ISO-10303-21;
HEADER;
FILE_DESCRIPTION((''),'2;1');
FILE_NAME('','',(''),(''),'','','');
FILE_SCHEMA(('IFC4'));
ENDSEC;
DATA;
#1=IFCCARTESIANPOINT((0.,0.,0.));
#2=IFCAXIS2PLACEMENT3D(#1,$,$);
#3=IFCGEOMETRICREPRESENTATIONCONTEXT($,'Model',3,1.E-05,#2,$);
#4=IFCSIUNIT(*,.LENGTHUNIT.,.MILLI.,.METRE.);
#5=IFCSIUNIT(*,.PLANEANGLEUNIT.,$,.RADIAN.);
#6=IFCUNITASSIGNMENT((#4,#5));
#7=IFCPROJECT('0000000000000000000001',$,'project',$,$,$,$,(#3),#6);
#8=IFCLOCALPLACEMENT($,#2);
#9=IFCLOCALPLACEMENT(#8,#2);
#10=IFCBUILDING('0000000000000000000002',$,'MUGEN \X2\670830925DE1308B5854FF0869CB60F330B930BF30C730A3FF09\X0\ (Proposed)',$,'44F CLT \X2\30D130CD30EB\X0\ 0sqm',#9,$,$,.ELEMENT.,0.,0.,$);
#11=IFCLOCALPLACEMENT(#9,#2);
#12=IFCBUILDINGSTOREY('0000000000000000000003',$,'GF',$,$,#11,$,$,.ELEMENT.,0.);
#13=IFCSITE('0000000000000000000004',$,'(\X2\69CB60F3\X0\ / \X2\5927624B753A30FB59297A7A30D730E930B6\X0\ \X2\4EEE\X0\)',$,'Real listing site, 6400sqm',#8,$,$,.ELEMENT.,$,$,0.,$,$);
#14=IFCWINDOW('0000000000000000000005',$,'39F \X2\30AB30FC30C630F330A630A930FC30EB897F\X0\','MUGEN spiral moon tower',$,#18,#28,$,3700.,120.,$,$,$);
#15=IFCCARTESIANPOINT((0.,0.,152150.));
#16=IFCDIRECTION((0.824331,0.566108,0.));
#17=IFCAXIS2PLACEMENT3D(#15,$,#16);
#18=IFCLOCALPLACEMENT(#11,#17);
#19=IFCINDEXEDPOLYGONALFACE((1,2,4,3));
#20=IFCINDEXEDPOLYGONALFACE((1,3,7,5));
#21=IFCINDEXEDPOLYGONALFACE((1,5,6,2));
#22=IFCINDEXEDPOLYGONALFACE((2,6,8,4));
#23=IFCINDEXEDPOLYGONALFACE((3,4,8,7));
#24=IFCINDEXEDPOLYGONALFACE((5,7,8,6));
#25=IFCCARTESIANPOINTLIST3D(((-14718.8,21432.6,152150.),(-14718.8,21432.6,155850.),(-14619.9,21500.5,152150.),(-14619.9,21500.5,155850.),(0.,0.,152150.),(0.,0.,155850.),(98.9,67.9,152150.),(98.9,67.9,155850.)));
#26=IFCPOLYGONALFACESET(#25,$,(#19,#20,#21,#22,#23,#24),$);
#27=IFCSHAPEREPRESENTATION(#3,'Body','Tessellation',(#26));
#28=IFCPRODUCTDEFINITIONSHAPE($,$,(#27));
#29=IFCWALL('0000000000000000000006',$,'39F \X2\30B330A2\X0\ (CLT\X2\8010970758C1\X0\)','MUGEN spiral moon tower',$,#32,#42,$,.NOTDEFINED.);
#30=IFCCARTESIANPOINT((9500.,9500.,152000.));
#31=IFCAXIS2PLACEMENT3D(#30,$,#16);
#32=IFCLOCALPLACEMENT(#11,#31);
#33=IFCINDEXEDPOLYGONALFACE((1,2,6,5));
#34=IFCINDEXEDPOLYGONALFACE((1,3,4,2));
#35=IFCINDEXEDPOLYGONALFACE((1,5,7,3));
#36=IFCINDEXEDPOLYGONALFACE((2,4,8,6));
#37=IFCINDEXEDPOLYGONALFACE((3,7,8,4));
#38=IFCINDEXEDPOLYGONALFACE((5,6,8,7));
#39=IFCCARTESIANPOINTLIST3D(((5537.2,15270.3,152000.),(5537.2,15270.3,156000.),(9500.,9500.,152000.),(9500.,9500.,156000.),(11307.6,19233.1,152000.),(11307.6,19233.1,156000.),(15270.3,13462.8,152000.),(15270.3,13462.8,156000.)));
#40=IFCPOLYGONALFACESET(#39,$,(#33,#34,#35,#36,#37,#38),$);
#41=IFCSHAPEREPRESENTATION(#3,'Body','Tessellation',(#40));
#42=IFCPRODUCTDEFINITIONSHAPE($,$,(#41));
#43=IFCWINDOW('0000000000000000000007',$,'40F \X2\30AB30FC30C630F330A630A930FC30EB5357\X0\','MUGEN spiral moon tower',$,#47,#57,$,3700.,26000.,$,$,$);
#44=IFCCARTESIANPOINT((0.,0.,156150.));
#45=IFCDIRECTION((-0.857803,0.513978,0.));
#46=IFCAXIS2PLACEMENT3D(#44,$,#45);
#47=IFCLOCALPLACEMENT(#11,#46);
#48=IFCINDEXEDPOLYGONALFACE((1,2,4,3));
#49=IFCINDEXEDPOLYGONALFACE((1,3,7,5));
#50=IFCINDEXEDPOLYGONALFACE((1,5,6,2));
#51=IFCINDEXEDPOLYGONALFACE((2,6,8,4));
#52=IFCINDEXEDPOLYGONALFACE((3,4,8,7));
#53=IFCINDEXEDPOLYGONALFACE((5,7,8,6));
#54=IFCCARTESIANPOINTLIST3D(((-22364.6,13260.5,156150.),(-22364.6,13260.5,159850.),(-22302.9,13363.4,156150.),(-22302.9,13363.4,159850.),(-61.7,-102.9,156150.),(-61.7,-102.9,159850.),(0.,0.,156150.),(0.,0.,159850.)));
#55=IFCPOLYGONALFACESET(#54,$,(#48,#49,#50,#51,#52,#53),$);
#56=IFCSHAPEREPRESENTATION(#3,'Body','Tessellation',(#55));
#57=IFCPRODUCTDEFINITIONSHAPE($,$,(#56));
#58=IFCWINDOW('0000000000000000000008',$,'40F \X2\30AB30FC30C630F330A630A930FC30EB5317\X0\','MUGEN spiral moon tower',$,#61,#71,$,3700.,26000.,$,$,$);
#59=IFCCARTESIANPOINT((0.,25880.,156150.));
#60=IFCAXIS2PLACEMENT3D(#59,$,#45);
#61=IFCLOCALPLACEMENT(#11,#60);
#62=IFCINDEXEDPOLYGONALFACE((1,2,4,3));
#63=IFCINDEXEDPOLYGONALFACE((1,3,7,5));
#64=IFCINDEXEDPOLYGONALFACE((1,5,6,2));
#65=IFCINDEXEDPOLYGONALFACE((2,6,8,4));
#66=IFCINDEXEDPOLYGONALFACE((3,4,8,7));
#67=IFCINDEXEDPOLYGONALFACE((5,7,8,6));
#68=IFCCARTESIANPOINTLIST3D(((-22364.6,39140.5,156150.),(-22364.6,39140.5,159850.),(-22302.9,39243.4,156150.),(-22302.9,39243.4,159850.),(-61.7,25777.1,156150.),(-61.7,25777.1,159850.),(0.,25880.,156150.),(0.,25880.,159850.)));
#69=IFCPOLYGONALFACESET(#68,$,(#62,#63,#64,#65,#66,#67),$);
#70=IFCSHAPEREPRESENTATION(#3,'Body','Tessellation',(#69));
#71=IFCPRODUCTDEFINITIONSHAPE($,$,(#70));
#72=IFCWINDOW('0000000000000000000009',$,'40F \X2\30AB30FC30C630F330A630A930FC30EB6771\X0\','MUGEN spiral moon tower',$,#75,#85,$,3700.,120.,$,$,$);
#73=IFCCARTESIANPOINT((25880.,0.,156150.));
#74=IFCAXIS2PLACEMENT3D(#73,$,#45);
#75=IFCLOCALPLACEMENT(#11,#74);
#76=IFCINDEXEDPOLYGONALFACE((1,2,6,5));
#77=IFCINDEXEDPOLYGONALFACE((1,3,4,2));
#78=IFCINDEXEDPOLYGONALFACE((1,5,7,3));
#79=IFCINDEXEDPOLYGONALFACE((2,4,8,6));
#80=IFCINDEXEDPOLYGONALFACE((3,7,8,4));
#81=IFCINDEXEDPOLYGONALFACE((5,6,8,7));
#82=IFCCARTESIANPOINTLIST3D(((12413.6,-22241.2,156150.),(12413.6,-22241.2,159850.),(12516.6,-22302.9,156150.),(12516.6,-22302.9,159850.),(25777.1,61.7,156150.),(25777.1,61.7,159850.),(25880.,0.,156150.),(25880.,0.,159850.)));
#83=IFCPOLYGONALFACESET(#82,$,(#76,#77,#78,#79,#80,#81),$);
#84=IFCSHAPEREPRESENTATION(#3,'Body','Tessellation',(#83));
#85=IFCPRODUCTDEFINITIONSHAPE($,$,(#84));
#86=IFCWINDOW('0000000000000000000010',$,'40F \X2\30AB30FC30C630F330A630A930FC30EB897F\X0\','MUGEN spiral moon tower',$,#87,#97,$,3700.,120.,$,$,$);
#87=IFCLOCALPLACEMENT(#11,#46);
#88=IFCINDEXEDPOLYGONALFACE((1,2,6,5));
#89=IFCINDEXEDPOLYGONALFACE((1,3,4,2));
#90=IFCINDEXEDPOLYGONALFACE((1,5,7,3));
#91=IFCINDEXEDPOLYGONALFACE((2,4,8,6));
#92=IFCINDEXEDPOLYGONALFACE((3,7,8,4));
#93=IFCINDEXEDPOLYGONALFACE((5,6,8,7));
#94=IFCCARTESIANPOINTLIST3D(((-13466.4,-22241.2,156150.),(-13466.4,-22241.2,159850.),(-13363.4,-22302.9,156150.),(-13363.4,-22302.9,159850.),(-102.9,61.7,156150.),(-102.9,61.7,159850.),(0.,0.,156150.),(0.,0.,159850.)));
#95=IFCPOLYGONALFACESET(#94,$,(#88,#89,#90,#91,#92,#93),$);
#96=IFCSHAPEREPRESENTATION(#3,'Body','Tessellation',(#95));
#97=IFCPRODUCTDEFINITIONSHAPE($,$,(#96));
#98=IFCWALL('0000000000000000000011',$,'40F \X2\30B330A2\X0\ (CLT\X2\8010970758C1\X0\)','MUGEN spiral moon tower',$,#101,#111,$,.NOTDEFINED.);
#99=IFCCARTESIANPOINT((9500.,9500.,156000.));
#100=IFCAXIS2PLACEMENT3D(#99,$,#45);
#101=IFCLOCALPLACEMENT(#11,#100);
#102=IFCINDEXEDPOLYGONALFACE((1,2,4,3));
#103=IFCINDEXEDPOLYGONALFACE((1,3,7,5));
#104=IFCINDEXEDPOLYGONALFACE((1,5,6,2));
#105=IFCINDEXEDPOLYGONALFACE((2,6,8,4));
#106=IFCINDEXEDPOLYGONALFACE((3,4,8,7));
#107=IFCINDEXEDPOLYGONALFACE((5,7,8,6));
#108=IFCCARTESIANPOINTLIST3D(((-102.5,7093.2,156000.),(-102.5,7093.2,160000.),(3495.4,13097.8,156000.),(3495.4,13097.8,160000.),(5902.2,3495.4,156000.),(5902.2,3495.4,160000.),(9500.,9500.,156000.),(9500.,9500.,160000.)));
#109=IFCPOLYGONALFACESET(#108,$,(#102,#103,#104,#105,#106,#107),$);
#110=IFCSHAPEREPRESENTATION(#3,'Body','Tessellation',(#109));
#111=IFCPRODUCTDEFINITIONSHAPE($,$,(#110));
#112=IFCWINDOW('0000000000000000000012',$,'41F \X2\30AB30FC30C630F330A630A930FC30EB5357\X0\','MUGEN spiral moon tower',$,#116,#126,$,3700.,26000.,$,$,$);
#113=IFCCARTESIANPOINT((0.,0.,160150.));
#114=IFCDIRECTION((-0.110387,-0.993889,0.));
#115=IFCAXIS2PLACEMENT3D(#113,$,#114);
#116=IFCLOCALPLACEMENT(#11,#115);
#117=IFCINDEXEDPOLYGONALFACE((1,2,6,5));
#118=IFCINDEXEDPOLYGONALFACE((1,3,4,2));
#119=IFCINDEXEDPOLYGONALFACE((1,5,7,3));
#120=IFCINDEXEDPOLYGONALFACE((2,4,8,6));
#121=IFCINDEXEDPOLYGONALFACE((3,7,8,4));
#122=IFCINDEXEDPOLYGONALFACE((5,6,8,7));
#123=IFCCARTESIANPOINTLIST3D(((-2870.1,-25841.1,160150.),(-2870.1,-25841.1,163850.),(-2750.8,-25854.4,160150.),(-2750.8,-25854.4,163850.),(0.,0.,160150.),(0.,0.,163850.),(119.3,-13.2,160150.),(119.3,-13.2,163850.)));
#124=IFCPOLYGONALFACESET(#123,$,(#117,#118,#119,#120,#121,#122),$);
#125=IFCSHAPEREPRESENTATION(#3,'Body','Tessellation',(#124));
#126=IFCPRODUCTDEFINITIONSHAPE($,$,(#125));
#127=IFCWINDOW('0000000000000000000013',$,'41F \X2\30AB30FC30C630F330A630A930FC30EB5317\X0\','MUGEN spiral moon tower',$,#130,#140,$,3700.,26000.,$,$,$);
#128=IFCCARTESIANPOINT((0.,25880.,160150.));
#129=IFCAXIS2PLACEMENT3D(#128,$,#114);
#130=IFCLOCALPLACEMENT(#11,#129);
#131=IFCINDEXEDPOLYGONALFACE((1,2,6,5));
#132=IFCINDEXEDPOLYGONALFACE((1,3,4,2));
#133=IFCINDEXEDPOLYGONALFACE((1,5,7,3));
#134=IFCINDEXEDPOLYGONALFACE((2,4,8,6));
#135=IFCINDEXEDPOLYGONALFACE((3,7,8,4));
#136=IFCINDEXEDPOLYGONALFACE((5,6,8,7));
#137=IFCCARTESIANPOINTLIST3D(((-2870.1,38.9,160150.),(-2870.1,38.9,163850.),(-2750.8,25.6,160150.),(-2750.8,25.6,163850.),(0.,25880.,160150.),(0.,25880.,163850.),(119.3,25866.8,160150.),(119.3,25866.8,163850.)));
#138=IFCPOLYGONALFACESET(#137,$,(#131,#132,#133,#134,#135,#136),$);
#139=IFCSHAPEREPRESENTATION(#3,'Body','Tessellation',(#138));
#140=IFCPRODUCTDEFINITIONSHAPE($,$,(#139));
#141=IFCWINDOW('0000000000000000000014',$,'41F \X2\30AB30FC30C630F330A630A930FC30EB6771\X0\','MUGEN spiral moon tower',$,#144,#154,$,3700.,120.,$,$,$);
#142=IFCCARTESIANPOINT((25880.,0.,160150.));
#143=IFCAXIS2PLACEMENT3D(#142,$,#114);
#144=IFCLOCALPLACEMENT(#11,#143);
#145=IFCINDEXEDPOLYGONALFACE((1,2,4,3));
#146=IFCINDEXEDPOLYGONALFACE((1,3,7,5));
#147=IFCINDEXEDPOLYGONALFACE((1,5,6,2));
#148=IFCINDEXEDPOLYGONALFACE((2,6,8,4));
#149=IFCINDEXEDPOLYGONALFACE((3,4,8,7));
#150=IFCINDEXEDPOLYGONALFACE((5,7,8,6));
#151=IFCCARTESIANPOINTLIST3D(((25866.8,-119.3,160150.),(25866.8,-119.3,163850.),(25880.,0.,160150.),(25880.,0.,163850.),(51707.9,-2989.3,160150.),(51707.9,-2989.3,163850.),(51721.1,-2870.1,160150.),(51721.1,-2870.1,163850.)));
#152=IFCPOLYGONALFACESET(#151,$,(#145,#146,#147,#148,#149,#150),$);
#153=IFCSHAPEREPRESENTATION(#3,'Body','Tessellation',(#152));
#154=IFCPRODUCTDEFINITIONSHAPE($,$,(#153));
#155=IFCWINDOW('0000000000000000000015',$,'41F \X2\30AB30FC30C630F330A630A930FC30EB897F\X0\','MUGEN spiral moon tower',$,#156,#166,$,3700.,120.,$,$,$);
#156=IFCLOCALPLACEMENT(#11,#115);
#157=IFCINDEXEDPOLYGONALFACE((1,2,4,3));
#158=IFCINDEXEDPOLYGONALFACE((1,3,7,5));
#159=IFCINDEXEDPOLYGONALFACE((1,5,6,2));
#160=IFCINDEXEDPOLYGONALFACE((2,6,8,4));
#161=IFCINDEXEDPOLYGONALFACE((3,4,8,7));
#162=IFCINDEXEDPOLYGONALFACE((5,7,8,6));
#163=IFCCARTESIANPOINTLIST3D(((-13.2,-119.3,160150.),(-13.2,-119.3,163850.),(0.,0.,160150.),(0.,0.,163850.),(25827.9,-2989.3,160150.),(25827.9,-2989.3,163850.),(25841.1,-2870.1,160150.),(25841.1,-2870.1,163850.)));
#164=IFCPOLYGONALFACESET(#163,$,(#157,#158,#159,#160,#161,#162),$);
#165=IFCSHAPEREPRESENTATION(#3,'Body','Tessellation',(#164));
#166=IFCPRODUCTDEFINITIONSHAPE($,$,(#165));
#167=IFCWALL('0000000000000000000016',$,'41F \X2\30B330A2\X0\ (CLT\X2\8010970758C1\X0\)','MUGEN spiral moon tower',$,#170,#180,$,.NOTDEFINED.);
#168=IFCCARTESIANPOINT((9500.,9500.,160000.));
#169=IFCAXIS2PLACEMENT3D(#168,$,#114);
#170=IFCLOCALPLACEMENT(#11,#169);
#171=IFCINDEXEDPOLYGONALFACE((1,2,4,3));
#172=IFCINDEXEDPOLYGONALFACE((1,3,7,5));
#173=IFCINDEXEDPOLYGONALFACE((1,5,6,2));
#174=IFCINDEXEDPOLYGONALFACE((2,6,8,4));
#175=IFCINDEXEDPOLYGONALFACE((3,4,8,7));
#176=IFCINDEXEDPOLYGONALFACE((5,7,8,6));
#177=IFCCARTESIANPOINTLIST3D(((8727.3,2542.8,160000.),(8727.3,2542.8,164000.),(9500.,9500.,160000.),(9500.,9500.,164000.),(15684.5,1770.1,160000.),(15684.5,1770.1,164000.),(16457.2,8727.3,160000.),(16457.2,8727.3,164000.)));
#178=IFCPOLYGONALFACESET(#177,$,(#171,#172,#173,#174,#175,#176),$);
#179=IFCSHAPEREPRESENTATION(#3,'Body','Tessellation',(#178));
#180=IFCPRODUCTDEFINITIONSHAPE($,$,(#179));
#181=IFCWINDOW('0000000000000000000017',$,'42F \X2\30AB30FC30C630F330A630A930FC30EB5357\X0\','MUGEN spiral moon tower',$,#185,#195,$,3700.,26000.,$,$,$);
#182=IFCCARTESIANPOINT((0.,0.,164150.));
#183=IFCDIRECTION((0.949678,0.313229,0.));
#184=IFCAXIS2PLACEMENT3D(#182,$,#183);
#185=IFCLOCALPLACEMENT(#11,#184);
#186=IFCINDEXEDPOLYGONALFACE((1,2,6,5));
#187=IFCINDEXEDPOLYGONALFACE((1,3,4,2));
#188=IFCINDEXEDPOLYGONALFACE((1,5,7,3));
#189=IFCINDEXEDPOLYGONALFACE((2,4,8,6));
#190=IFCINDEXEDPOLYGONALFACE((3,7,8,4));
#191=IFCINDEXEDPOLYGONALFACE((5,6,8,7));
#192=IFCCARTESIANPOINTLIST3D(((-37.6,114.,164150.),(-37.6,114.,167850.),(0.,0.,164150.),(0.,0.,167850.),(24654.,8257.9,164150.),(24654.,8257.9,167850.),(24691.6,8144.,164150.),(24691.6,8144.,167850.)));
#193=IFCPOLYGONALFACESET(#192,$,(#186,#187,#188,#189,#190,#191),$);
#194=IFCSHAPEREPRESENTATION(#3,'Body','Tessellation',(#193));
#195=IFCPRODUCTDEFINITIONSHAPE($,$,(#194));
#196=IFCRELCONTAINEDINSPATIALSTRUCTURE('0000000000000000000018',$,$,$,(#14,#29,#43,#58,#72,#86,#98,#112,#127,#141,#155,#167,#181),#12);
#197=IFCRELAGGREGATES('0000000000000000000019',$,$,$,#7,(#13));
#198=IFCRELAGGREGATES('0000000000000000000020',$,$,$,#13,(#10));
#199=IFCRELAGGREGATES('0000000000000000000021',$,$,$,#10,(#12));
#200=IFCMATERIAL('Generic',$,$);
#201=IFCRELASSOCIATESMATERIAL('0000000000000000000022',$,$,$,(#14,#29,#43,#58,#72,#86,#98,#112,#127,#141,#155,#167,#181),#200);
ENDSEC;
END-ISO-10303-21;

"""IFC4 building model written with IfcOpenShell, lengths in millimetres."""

from ifc_helpers import new_model, si_unit, frame, frame_2d, origin, place, context, project, spatial, rectangle, extrude, material, element, save


model = new_model("IFC4")

# Units and contexts
model_context = context("Model", 3, precision=1e-05, world=origin())
ifc_project = project(units=[si_unit("LENGTHUNIT", "METRE", prefix="MILLI"), si_unit("PLANEANGLEUNIT", "RADIAN")], contexts=[model_context])

# Site, building, storey
site_placement = place(None, origin())
site = spatial("IfcSite", under=ifc_project, at=site_placement, Name="(構想 / 大手町・天空プラザ 仮)", ObjectType="Real listing site, 6400sqm", CompositionType="ELEMENT", RefElevation=0.0)
building_placement = place(site_placement, origin())
building = spatial("IfcBuilding", under=site, at=building_placement, Name="MUGEN 月を巡る塔（構想スタディ） (Proposed)", ObjectType="44F CLT パネル 0sqm", CompositionType="ELEMENT", ElevationOfRefHeight=0.0, ElevationOfTerrain=0.0)
storey_placement = place(building_placement, origin())
storey = spatial("IfcBuildingStorey", under=building, at=storey_placement, Name="GF", CompositionType="ELEMENT", Elevation=0.0)

# Shared definitions
ifc_material = material(Name="Generic")

# Window
window_1_placement = place(storey_placement, frame((0.0, 0.0, 152150.0), x_axis=(0.824331, 0.566108, 0.0)))
element("IfcWindow", 1, at=window_1_placement, inside=storey, material=ifc_material, Name="39F カーテンウォール西", Description="MUGEN spiral moon tower", OverallHeight=3700.0, OverallWidth=120.0, context=model_context, shape_type="SweptSolid", body=[
    extrude(rectangle(XDim=120.0, YDim=26000.0, at=frame_2d((60.0, 13000.0))), frame((0.0, 0.0, 152150.0), x_axis=(0.824331, 0.566108, 0.0)), (0.0, 0.0, 1.0), 3700.0),
])

# Wall
wall_1_placement = place(storey_placement, frame((9500.0, 9500.0, 152000.0), x_axis=(0.824331, 0.566108, 0.0)))
element("IfcWall", 2, at=wall_1_placement, inside=storey, material=ifc_material, Name="39F コア (CLT耐震壁)", Description="MUGEN spiral moon tower", PredefinedType="NOTDEFINED", context=model_context, shape_type="SweptSolid", body=[
    extrude(rectangle(XDim=7000.0, YDim=7000.0, at=frame_2d((3500.0, 3500.0))), frame((9500.0, 9500.0, 152000.0), x_axis=(0.824331, 0.566108, 0.0)), (0.0, 0.0, 1.0), 4000.0),
])

# Windows
window_2_placement = place(storey_placement, frame((0.0, 0.0, 156150.0), x_axis=(-0.857803, 0.513978, 0.0)))
element("IfcWindow", 3, at=window_2_placement, inside=storey, material=ifc_material, Name="40F カーテンウォール南", Description="MUGEN spiral moon tower", OverallHeight=3700.0, OverallWidth=26000.0, context=model_context, shape_type="SweptSolid", body=[
    extrude(rectangle(XDim=26000.0, YDim=120.0, at=frame_2d((13000.0, 60.0))), frame((0.0, 0.0, 156150.0), x_axis=(-0.857803, 0.513978, 0.0)), (0.0, 0.0, 1.0), 3700.0),
])
window_3_placement = place(storey_placement, frame((0.0, 25880.0, 156150.0), x_axis=(-0.857803, 0.513978, 0.0)))
element("IfcWindow", 4, at=window_3_placement, inside=storey, material=ifc_material, Name="40F カーテンウォール北", Description="MUGEN spiral moon tower", OverallHeight=3700.0, OverallWidth=26000.0, context=model_context, shape_type="SweptSolid", body=[
    extrude(rectangle(XDim=26000.0, YDim=120.0, at=frame_2d((13000.0, 60.0))), frame((0.0, 25880.0, 156150.0), x_axis=(-0.857803, 0.513978, 0.0)), (0.0, 0.0, 1.0), 3700.0),
])
window_4_placement = place(storey_placement, frame((25880.0, 0.0, 156150.0), x_axis=(-0.857803, 0.513978, 0.0)))
element("IfcWindow", 5, at=window_4_placement, inside=storey, material=ifc_material, Name="40F カーテンウォール東", Description="MUGEN spiral moon tower", OverallHeight=3700.0, OverallWidth=120.0, context=model_context, shape_type="SweptSolid", body=[
    extrude(rectangle(XDim=120.0, YDim=26000.0, at=frame_2d((60.0, 13000.0))), frame((25880.0, 0.0, 156150.0), x_axis=(-0.857803, 0.513978, 0.0)), (0.0, 0.0, 1.0), 3700.0),
])
window_5_placement = place(storey_placement, frame((0.0, 0.0, 156150.0), x_axis=(-0.857803, 0.513978, 0.0)))
element("IfcWindow", 6, at=window_5_placement, inside=storey, material=ifc_material, Name="40F カーテンウォール西", Description="MUGEN spiral moon tower", OverallHeight=3700.0, OverallWidth=120.0, context=model_context, shape_type="SweptSolid", body=[
    extrude(rectangle(XDim=120.0, YDim=26000.0, at=frame_2d((60.0, 13000.0))), frame((0.0, 0.0, 156150.0), x_axis=(-0.857803, 0.513978, 0.0)), (0.0, 0.0, 1.0), 3700.0),
])

# Wall
wall_2_placement = place(storey_placement, frame((9500.0, 9500.0, 156000.0), x_axis=(-0.857803, 0.513978, 0.0)))
element("IfcWall", 7, at=wall_2_placement, inside=storey, material=ifc_material, Name="40F コア (CLT耐震壁)", Description="MUGEN spiral moon tower", PredefinedType="NOTDEFINED", context=model_context, shape_type="SweptSolid", body=[
    extrude(rectangle(XDim=7000.0, YDim=7000.0, at=frame_2d((3500.0, 3500.0))), frame((9500.0, 9500.0, 156000.0), x_axis=(-0.857803, 0.513978, 0.0)), (0.0, 0.0, 1.0), 4000.0),
])

# Windows
window_6_placement = place(storey_placement, frame((0.0, 0.0, 160150.0), x_axis=(-0.110387, -0.993889, 0.0)))
element("IfcWindow", 8, at=window_6_placement, inside=storey, material=ifc_material, Name="41F カーテンウォール南", Description="MUGEN spiral moon tower", OverallHeight=3700.0, OverallWidth=26000.0, context=model_context, shape_type="SweptSolid", body=[
    extrude(rectangle(XDim=26000.0, YDim=120.0, at=frame_2d((13000.0, 60.0))), frame((0.0, 0.0, 160150.0), x_axis=(-0.110387, -0.993889, 0.0)), (0.0, 0.0, 1.0), 3700.0),
])
window_7_placement = place(storey_placement, frame((0.0, 25880.0, 160150.0), x_axis=(-0.110387, -0.993889, 0.0)))
element("IfcWindow", 9, at=window_7_placement, inside=storey, material=ifc_material, Name="41F カーテンウォール北", Description="MUGEN spiral moon tower", OverallHeight=3700.0, OverallWidth=26000.0, context=model_context, shape_type="SweptSolid", body=[
    extrude(rectangle(XDim=26000.0, YDim=120.0, at=frame_2d((13000.0, 60.0))), frame((0.0, 25880.0, 160150.0), x_axis=(-0.110387, -0.993889, 0.0)), (0.0, 0.0, 1.0), 3700.0),
])
window_8_placement = place(storey_placement, frame((25880.0, 0.0, 160150.0), x_axis=(-0.110387, -0.993889, 0.0)))
element("IfcWindow", 10, at=window_8_placement, inside=storey, material=ifc_material, Name="41F カーテンウォール東", Description="MUGEN spiral moon tower", OverallHeight=3700.0, OverallWidth=120.0, context=model_context, shape_type="SweptSolid", body=[
    extrude(rectangle(XDim=120.0, YDim=26000.0, at=frame_2d((60.0, 13000.0))), frame((25880.0, 0.0, 160150.0), x_axis=(-0.110387, -0.993889, 0.0)), (0.0, 0.0, 1.0), 3700.0),
])
window_9_placement = place(storey_placement, frame((0.0, 0.0, 160150.0), x_axis=(-0.110387, -0.993889, 0.0)))
element("IfcWindow", 11, at=window_9_placement, inside=storey, material=ifc_material, Name="41F カーテンウォール西", Description="MUGEN spiral moon tower", OverallHeight=3700.0, OverallWidth=120.0, context=model_context, shape_type="SweptSolid", body=[
    extrude(rectangle(XDim=120.0, YDim=26000.0, at=frame_2d((60.0, 13000.0))), frame((0.0, 0.0, 160150.0), x_axis=(-0.110387, -0.993889, 0.0)), (0.0, 0.0, 1.0), 3700.0),
])

# Wall
wall_3_placement = place(storey_placement, frame((9500.0, 9500.0, 160000.0), x_axis=(-0.110387, -0.993889, 0.0)))
element("IfcWall", 12, at=wall_3_placement, inside=storey, material=ifc_material, Name="41F コア (CLT耐震壁)", Description="MUGEN spiral moon tower", PredefinedType="NOTDEFINED", context=model_context, shape_type="SweptSolid", body=[
    extrude(rectangle(XDim=7000.0, YDim=7000.0, at=frame_2d((3500.0, 3500.0))), frame((9500.0, 9500.0, 160000.0), x_axis=(-0.110387, -0.993889, 0.0)), (0.0, 0.0, 1.0), 4000.0),
])

# Window
window_10_placement = place(storey_placement, frame((0.0, 0.0, 164150.0), x_axis=(0.949678, 0.313229, 0.0)))
element("IfcWindow", 13, at=window_10_placement, inside=storey, material=ifc_material, Name="42F カーテンウォール南", Description="MUGEN spiral moon tower", OverallHeight=3700.0, OverallWidth=26000.0, context=model_context, shape_type="SweptSolid", body=[
    extrude(rectangle(XDim=26000.0, YDim=120.0, at=frame_2d((13000.0, 60.0))), frame((0.0, 0.0, 164150.0), x_axis=(0.949678, 0.313229, 0.0)), (0.0, 0.0, 1.0), 3700.0),
])

save(model, "model.ifc")
